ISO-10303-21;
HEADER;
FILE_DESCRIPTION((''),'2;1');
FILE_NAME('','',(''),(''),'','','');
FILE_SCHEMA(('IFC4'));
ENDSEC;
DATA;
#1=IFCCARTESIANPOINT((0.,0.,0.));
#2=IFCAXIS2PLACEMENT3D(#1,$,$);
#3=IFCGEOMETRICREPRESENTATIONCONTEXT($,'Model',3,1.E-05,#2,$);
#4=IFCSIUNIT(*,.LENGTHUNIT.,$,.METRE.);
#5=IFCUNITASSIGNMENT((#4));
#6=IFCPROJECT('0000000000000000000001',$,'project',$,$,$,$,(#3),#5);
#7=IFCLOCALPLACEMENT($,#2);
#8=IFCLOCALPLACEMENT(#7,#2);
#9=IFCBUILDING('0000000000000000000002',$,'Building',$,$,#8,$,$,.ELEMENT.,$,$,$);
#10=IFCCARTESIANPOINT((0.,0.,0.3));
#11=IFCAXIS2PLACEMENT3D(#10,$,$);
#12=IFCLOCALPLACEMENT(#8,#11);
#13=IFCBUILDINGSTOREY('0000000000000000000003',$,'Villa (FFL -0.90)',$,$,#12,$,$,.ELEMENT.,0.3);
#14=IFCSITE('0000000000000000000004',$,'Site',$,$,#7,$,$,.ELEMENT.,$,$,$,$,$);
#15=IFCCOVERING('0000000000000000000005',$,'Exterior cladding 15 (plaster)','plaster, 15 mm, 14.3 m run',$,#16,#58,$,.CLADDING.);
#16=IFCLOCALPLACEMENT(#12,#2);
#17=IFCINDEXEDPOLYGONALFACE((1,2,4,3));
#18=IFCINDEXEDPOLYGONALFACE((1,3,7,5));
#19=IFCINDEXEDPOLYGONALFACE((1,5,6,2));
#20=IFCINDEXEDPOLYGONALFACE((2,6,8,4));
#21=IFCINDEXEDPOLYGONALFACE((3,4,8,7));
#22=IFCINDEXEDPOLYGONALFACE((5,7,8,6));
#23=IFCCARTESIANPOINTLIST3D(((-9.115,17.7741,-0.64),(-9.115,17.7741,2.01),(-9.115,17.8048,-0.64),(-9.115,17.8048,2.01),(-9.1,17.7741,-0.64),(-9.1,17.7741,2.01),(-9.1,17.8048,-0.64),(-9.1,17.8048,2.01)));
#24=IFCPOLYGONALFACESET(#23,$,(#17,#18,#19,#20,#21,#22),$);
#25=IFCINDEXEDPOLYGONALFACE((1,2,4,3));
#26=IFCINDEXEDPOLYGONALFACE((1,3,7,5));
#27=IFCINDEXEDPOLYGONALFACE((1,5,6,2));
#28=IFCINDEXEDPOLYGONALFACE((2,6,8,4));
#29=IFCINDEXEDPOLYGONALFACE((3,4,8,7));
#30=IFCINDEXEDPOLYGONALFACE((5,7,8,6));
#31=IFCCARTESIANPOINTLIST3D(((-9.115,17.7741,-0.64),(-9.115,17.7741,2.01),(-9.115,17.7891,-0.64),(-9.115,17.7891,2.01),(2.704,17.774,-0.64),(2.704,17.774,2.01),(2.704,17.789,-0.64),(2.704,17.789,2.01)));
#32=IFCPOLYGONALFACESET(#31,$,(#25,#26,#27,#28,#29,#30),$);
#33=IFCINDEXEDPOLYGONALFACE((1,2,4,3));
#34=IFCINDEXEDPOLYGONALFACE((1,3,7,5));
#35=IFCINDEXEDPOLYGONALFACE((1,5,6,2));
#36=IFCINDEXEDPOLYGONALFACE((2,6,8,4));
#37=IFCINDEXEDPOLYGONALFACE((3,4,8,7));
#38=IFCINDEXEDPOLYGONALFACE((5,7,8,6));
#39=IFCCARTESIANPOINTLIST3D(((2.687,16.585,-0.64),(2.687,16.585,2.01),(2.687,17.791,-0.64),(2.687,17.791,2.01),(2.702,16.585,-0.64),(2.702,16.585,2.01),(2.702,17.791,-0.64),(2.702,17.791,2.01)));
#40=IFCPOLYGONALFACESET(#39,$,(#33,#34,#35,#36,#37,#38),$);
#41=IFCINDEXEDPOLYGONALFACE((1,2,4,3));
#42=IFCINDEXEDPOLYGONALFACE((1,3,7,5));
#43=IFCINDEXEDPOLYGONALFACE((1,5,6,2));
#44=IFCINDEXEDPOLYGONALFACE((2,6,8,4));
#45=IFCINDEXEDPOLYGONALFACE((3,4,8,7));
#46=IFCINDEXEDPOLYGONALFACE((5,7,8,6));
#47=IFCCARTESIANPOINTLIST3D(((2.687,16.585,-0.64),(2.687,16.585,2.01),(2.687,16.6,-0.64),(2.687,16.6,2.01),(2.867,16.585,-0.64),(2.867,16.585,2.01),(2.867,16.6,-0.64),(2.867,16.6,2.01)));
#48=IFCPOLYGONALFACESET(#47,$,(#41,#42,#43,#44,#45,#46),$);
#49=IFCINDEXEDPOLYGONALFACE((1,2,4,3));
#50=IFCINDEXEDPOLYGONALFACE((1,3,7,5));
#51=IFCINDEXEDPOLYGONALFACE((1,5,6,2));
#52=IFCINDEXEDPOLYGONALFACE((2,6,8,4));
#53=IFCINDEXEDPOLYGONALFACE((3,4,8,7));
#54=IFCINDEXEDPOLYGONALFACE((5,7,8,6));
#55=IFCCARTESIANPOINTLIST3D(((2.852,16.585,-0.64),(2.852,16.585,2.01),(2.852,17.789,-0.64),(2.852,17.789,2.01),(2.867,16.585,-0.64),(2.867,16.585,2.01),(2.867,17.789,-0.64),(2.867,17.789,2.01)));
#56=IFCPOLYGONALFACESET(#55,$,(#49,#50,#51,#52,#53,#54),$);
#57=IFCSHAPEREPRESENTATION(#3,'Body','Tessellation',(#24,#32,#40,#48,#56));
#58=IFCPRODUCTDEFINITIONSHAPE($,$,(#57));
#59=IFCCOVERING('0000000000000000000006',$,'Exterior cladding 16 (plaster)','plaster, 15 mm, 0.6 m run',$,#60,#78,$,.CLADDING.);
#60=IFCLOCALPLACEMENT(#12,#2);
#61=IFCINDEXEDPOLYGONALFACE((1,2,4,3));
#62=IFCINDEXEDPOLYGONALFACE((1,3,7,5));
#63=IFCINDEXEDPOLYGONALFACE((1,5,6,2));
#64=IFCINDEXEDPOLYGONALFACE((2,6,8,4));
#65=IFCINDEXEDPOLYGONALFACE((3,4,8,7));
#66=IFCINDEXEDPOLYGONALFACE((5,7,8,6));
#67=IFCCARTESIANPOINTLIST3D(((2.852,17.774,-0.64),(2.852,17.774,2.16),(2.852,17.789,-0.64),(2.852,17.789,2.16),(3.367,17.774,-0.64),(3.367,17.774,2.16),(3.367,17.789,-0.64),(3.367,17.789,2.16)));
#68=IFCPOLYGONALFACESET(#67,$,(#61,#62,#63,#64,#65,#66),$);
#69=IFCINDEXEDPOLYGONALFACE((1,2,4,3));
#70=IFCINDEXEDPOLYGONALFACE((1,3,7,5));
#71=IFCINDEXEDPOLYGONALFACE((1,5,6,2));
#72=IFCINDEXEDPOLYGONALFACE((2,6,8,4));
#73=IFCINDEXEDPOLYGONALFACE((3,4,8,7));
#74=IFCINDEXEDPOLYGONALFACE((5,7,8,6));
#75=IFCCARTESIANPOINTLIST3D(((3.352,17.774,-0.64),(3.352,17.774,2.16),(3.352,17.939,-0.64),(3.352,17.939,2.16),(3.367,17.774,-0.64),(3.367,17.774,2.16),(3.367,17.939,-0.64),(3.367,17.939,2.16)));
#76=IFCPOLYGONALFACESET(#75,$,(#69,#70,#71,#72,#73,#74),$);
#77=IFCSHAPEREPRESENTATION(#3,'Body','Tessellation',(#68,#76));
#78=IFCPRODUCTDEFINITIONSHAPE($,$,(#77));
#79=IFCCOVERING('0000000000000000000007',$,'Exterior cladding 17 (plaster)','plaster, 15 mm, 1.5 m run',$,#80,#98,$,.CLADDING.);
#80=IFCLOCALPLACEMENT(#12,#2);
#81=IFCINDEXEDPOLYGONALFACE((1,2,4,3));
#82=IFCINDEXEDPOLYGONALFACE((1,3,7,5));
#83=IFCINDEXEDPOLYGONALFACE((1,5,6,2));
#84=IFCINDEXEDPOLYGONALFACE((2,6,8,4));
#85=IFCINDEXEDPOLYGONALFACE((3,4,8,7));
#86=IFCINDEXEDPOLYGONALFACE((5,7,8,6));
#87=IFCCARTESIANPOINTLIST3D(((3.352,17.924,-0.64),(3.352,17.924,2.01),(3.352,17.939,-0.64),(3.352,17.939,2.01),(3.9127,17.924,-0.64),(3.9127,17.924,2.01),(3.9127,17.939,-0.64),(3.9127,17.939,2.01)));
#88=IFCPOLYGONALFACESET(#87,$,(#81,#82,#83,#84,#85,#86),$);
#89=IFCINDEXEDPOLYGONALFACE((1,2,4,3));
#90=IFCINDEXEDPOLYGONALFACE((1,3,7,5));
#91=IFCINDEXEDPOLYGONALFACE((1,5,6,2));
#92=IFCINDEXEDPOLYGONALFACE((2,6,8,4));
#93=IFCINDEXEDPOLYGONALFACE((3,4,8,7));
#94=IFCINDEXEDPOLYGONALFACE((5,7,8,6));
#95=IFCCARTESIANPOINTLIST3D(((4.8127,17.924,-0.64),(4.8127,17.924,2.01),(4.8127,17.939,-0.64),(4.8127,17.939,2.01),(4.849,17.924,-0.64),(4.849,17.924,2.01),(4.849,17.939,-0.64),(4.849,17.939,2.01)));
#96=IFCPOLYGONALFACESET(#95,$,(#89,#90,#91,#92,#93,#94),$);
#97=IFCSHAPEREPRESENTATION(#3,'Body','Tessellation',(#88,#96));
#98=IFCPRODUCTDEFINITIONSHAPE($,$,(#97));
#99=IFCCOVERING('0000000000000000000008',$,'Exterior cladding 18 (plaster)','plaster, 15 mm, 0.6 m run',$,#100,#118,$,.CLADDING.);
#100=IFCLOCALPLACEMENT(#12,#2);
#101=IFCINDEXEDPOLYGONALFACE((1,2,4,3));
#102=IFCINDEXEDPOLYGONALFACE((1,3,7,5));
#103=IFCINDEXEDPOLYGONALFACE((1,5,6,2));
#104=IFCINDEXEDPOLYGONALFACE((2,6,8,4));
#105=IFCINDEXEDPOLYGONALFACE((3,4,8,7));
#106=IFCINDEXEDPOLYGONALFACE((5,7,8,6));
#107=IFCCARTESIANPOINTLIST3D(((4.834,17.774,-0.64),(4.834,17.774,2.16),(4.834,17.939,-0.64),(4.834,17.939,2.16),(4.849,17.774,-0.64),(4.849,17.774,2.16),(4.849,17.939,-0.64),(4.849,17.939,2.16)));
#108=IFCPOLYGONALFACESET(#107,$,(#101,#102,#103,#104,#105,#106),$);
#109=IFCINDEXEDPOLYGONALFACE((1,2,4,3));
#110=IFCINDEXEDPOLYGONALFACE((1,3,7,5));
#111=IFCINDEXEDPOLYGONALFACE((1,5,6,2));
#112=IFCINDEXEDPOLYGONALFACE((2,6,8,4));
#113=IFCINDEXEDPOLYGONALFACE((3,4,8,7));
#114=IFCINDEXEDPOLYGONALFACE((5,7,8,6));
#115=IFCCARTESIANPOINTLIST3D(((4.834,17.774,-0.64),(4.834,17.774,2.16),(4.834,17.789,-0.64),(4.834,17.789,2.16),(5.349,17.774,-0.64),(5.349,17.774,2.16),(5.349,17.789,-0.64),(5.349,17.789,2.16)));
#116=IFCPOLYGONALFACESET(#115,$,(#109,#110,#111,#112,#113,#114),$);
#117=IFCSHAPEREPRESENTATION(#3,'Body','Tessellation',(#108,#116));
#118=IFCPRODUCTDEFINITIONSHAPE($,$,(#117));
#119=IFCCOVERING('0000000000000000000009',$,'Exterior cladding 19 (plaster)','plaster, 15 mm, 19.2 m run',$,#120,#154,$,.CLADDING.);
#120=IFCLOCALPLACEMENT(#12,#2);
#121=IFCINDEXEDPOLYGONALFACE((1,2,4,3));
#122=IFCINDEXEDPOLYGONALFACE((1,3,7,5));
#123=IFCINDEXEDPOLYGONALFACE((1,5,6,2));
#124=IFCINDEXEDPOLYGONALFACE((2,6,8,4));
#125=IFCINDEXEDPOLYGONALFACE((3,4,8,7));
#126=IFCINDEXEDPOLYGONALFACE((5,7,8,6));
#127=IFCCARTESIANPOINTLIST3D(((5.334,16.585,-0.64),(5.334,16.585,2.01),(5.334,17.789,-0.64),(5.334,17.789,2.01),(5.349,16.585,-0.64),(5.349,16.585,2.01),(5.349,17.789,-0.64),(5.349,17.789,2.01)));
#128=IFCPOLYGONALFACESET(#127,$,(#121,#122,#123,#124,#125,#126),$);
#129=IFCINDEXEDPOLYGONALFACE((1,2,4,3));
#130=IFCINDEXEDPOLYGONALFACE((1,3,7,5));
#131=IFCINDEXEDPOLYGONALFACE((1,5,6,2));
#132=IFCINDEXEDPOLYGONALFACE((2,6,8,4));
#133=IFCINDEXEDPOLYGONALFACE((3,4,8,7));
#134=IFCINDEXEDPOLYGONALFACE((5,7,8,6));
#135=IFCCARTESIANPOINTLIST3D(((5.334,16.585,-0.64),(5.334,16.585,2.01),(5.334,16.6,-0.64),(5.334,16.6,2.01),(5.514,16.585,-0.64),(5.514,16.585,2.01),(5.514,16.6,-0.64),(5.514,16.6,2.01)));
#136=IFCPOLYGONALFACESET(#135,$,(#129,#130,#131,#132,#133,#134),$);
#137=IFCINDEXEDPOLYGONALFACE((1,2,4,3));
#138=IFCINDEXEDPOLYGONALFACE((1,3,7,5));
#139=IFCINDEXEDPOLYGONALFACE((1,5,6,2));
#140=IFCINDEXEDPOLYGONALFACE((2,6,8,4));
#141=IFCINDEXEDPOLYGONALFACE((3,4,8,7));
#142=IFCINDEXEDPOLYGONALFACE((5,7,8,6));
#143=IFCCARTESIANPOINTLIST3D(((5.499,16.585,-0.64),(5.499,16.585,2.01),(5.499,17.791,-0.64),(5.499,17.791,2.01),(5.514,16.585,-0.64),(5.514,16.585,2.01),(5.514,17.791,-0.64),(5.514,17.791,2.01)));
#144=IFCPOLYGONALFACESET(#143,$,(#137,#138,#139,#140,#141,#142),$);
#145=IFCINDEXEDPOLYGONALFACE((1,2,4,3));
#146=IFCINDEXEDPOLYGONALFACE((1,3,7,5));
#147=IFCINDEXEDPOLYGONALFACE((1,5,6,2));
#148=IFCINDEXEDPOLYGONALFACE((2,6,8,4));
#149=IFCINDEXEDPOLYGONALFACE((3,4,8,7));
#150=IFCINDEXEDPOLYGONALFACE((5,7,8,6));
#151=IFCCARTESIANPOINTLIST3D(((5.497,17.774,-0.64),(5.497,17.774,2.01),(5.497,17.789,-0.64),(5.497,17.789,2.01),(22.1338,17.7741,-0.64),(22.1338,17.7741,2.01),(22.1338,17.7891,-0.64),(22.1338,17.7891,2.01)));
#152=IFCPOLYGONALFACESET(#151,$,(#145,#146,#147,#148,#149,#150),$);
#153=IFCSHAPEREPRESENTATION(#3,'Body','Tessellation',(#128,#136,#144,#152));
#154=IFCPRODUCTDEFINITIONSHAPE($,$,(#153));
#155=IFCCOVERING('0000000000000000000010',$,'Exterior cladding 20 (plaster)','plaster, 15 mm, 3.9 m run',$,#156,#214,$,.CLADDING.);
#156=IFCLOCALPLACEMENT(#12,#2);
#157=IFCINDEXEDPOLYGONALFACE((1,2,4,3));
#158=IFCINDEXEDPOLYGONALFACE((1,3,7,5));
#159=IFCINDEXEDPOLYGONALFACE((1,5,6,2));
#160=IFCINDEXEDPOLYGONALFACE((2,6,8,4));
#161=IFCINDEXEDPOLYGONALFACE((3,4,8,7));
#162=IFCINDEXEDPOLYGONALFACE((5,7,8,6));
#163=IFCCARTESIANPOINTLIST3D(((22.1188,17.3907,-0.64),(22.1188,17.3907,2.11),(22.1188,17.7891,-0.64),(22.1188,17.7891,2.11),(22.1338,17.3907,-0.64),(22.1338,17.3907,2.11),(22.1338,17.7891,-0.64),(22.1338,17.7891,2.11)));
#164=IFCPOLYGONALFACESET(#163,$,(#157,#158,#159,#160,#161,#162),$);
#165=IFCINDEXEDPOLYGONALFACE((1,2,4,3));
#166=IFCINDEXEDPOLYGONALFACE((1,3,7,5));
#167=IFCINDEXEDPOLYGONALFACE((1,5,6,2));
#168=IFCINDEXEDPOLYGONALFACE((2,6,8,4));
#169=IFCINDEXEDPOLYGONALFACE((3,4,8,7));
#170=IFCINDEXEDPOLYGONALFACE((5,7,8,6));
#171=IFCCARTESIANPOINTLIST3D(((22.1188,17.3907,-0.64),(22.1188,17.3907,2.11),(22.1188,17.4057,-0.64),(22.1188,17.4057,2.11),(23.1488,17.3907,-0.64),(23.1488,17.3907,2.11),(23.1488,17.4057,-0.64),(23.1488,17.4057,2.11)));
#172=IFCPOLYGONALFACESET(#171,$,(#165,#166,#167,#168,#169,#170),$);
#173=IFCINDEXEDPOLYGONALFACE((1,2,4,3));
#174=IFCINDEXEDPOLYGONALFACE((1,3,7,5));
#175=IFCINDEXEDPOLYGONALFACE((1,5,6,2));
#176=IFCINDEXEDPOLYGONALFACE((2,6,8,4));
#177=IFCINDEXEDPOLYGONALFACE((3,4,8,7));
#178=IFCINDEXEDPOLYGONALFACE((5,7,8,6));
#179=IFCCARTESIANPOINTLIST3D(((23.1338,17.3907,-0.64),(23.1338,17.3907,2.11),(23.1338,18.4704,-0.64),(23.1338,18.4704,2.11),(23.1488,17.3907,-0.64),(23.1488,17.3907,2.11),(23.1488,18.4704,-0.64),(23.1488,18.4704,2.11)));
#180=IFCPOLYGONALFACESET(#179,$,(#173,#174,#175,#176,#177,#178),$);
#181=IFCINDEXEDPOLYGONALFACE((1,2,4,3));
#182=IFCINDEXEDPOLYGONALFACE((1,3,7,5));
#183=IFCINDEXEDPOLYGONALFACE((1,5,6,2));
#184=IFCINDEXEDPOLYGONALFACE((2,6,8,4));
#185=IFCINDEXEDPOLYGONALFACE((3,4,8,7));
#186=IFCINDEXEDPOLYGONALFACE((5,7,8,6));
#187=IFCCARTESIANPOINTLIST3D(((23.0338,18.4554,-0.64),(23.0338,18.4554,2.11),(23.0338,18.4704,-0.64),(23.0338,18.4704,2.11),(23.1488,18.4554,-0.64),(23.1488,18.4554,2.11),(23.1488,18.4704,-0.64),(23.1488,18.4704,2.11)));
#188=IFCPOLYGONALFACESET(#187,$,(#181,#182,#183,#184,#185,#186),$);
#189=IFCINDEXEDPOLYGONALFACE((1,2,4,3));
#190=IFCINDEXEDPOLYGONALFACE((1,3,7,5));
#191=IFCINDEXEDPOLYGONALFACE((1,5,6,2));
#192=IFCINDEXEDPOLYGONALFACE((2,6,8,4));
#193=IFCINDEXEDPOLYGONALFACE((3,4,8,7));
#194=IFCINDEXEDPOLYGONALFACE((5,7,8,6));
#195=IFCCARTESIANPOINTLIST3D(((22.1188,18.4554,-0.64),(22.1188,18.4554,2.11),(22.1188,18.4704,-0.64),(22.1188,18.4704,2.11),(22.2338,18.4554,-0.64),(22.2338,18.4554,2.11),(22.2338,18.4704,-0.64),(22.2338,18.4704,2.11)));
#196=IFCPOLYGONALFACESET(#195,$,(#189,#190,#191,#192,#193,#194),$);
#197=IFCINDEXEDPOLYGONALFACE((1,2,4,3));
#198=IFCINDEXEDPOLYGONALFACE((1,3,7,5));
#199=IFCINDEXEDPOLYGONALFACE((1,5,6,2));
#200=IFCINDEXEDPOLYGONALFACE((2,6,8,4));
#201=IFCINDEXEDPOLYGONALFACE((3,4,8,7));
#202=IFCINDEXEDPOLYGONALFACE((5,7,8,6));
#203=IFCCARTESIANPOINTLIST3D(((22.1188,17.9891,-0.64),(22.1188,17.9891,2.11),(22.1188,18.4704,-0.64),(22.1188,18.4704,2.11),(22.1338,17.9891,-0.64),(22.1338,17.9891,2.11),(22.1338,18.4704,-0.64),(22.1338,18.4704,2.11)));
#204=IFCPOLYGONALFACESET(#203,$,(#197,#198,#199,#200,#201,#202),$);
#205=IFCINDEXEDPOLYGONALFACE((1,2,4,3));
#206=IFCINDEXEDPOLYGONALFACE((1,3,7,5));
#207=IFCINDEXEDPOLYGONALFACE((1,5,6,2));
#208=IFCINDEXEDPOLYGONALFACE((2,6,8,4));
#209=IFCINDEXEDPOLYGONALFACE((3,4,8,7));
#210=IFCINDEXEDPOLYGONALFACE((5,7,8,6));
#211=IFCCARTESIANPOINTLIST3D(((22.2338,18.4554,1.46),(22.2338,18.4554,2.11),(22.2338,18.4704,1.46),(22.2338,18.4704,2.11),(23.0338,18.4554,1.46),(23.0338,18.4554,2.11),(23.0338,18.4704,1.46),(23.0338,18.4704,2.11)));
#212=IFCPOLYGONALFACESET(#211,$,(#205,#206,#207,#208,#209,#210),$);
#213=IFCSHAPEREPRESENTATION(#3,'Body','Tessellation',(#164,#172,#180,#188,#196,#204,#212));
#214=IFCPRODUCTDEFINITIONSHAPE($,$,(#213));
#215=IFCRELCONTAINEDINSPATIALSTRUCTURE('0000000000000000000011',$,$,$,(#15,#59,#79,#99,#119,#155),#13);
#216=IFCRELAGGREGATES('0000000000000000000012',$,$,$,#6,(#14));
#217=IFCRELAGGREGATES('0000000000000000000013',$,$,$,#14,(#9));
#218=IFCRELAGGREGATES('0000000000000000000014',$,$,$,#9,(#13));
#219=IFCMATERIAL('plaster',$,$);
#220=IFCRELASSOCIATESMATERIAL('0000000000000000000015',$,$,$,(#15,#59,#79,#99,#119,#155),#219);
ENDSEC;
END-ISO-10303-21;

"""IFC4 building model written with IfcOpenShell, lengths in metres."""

from ifc_helpers import new_model, si_unit, frame, origin, origin_with_axes, place, context, project, spatial, polyline, outline, extrude, material, element, save


model = new_model("IFC4")

# Units and contexts
model_context = context("Model", 3, precision=1e-05, world=origin())
ifc_project = project(units=[si_unit("LENGTHUNIT", "METRE")], contexts=[model_context])

# Site, building, storey
site_placement = place(None, origin())
site = spatial("IfcSite", under=ifc_project, at=site_placement, Name="Site", CompositionType="ELEMENT")
building_placement = place(site_placement, origin())
building = spatial("IfcBuilding", under=site, at=building_placement, Name="Building", CompositionType="ELEMENT")
storey_placement = place(building_placement, frame((0.0, 0.0, 0.3)))
storey = spatial("IfcBuildingStorey", under=building, at=storey_placement, Name="Villa (FFL -0.90)", CompositionType="ELEMENT", Elevation=0.3)

# Coverings
ifc_material = material(Name="plaster")
covering_1_placement = place(storey_placement, origin_with_axes())
element("IfcCovering", 1, at=covering_1_placement, inside=storey, material=ifc_material, Name="Exterior cladding 15 (plaster)", Description="plaster, 15 mm, 14.3 m run", PredefinedType="CLADDING", context=model_context, shape_type="SweptSolid", body=[
    extrude(outline(polyline([(-9.115, 17.8048), (-9.115, 17.7741), (-9.1, 17.7741), (-9.1, 17.8048), (-9.115, 17.8048)])), frame((0.0, 0.0, -0.64)), (0.0, 0.0, 1.0), 2.65),
    extrude(outline(polyline([(-9.115, 17.7741), (2.704, 17.774), (2.704, 17.789), (-9.115, 17.7891), (-9.115, 17.7741)])), frame((0.0, 0.0, -0.64)), (0.0, 0.0, 1.0), 2.65),
    extrude(outline(polyline([(2.687, 17.791), (2.687, 16.585), (2.702, 16.585), (2.702, 17.791), (2.687, 17.791)])), frame((0.0, 0.0, -0.64)), (0.0, 0.0, 1.0), 2.65),
    extrude(outline(polyline([(2.687, 16.585), (2.867, 16.585), (2.867, 16.6), (2.687, 16.6), (2.687, 16.585)])), frame((0.0, 0.0, -0.64)), (0.0, 0.0, 1.0), 2.65),
    extrude(outline(polyline([(2.867, 16.585), (2.867, 17.789), (2.852, 17.789), (2.852, 16.585), (2.867, 16.585)])), frame((0.0, 0.0, -0.64)), (0.0, 0.0, 1.0), 2.65),
])
covering_2_placement = place(storey_placement, origin_with_axes())
element("IfcCovering", 2, at=covering_2_placement, inside=storey, material=ifc_material, Name="Exterior cladding 16 (plaster)", Description="plaster, 15 mm, 0.6 m run", PredefinedType="CLADDING", context=model_context, shape_type="SweptSolid", body=[
    extrude(outline(polyline([(2.852, 17.774), (3.367, 17.774), (3.367, 17.789), (2.852, 17.789), (2.852, 17.774)])), frame((0.0, 0.0, -0.64)), (0.0, 0.0, 1.0), 2.8),
    extrude(outline(polyline([(3.367, 17.774), (3.367, 17.939), (3.352, 17.939), (3.352, 17.774), (3.367, 17.774)])), frame((0.0, 0.0, -0.64)), (0.0, 0.0, 1.0), 2.8),
])
covering_3_placement = place(storey_placement, origin_with_axes())
element("IfcCovering", 3, at=covering_3_placement, inside=storey, material=ifc_material, Name="Exterior cladding 17 (plaster)", Description="plaster, 15 mm, 1.5 m run", PredefinedType="CLADDING", context=model_context, shape_type="SweptSolid", body=[
    extrude(outline(polyline([(3.352, 17.924), (3.9127, 17.924), (3.9127, 17.939), (3.352, 17.939), (3.352, 17.924)])), frame((0.0, 0.0, -0.64)), (0.0, 0.0, 1.0), 2.65),
    extrude(outline(polyline([(4.8127, 17.924), (4.849, 17.924), (4.849, 17.939), (4.8127, 17.939), (4.8127, 17.924)])), frame((0.0, 0.0, -0.64)), (0.0, 0.0, 1.0), 2.65),
])
covering_4_placement = place(storey_placement, origin_with_axes())
element("IfcCovering", 4, at=covering_4_placement, inside=storey, material=ifc_material, Name="Exterior cladding 18 (plaster)", Description="plaster, 15 mm, 0.6 m run", PredefinedType="CLADDING", context=model_context, shape_type="SweptSolid", body=[
    extrude(outline(polyline([(4.834, 17.939), (4.834, 17.774), (4.849, 17.774), (4.849, 17.939), (4.834, 17.939)])), frame((0.0, 0.0, -0.64)), (0.0, 0.0, 1.0), 2.8),
    extrude(outline(polyline([(4.834, 17.774), (5.349, 17.774), (5.349, 17.789), (4.834, 17.789), (4.834, 17.774)])), frame((0.0, 0.0, -0.64)), (0.0, 0.0, 1.0), 2.8),
])
covering_5_placement = place(storey_placement, origin_with_axes())
element("IfcCovering", 5, at=covering_5_placement, inside=storey, material=ifc_material, Name="Exterior cladding 19 (plaster)", Description="plaster, 15 mm, 19.2 m run", PredefinedType="CLADDING", context=model_context, shape_type="SweptSolid", body=[
    extrude(outline(polyline([(5.334, 17.789), (5.334, 16.585), (5.349, 16.585), (5.349, 17.789), (5.334, 17.789)])), frame((0.0, 0.0, -0.64)), (0.0, 0.0, 1.0), 2.65),
    extrude(outline(polyline([(5.334, 16.585), (5.514, 16.585), (5.514, 16.6), (5.334, 16.6), (5.334, 16.585)])), frame((0.0, 0.0, -0.64)), (0.0, 0.0, 1.0), 2.65),
    extrude(outline(polyline([(5.514, 16.585), (5.514, 17.791), (5.499, 17.791), (5.499, 16.585), (5.514, 16.585)])), frame((0.0, 0.0, -0.64)), (0.0, 0.0, 1.0), 2.65),
    extrude(outline(polyline([(5.497, 17.774), (22.1338, 17.7741), (22.1338, 17.7891), (5.497, 17.789), (5.497, 17.774)])), frame((0.0, 0.0, -0.64)), (0.0, 0.0, 1.0), 2.65),
])
covering_6_placement = place(storey_placement, origin_with_axes())
element("IfcCovering", 6, at=covering_6_placement, inside=storey, material=ifc_material, Name="Exterior cladding 20 (plaster)", Description="plaster, 15 mm, 3.9 m run", PredefinedType="CLADDING", context=model_context, shape_type="SweptSolid", body=[
    extrude(outline(polyline([(22.1188, 17.7891), (22.1188, 17.3907), (22.1338, 17.3907), (22.1338, 17.7891), (22.1188, 17.7891)])), frame((0.0, 0.0, -0.64)), (0.0, 0.0, 1.0), 2.75),
    extrude(outline(polyline([(22.1188, 17.3907), (23.1488, 17.3907), (23.1488, 17.4057), (22.1188, 17.4057), (22.1188, 17.3907)])), frame((0.0, 0.0, -0.64)), (0.0, 0.0, 1.0), 2.75),
    extrude(outline(polyline([(23.1488, 17.3907), (23.1488, 18.4704), (23.1338, 18.4704), (23.1338, 17.3907), (23.1488, 17.3907)])), frame((0.0, 0.0, -0.64)), (0.0, 0.0, 1.0), 2.75),
    extrude(outline(polyline([(23.1488, 18.4704), (23.0338, 18.4704), (23.0338, 18.4554), (23.1488, 18.4554), (23.1488, 18.4704)])), frame((0.0, 0.0, -0.64)), (0.0, 0.0, 1.0), 2.75),
    extrude(outline(polyline([(22.2338, 18.4704), (22.1188, 18.4704), (22.1188, 18.4554), (22.2338, 18.4554), (22.2338, 18.4704)])), frame((0.0, 0.0, -0.64)), (0.0, 0.0, 1.0), 2.75),
    extrude(outline(polyline([(22.1188, 18.4704), (22.1188, 17.9891), (22.1338, 17.9891), (22.1338, 18.4704), (22.1188, 18.4704)])), frame((0.0, 0.0, -0.64)), (0.0, 0.0, 1.0), 2.75),
    extrude(outline(polyline([(23.0338, 18.4704), (22.2338, 18.4704), (22.2338, 18.4554), (23.0338, 18.4554), (23.0338, 18.4704)])), frame((0.0, 0.0, 1.46)), (0.0, 0.0, 1.0), 0.65),
])

save(model, "model.ifc")
